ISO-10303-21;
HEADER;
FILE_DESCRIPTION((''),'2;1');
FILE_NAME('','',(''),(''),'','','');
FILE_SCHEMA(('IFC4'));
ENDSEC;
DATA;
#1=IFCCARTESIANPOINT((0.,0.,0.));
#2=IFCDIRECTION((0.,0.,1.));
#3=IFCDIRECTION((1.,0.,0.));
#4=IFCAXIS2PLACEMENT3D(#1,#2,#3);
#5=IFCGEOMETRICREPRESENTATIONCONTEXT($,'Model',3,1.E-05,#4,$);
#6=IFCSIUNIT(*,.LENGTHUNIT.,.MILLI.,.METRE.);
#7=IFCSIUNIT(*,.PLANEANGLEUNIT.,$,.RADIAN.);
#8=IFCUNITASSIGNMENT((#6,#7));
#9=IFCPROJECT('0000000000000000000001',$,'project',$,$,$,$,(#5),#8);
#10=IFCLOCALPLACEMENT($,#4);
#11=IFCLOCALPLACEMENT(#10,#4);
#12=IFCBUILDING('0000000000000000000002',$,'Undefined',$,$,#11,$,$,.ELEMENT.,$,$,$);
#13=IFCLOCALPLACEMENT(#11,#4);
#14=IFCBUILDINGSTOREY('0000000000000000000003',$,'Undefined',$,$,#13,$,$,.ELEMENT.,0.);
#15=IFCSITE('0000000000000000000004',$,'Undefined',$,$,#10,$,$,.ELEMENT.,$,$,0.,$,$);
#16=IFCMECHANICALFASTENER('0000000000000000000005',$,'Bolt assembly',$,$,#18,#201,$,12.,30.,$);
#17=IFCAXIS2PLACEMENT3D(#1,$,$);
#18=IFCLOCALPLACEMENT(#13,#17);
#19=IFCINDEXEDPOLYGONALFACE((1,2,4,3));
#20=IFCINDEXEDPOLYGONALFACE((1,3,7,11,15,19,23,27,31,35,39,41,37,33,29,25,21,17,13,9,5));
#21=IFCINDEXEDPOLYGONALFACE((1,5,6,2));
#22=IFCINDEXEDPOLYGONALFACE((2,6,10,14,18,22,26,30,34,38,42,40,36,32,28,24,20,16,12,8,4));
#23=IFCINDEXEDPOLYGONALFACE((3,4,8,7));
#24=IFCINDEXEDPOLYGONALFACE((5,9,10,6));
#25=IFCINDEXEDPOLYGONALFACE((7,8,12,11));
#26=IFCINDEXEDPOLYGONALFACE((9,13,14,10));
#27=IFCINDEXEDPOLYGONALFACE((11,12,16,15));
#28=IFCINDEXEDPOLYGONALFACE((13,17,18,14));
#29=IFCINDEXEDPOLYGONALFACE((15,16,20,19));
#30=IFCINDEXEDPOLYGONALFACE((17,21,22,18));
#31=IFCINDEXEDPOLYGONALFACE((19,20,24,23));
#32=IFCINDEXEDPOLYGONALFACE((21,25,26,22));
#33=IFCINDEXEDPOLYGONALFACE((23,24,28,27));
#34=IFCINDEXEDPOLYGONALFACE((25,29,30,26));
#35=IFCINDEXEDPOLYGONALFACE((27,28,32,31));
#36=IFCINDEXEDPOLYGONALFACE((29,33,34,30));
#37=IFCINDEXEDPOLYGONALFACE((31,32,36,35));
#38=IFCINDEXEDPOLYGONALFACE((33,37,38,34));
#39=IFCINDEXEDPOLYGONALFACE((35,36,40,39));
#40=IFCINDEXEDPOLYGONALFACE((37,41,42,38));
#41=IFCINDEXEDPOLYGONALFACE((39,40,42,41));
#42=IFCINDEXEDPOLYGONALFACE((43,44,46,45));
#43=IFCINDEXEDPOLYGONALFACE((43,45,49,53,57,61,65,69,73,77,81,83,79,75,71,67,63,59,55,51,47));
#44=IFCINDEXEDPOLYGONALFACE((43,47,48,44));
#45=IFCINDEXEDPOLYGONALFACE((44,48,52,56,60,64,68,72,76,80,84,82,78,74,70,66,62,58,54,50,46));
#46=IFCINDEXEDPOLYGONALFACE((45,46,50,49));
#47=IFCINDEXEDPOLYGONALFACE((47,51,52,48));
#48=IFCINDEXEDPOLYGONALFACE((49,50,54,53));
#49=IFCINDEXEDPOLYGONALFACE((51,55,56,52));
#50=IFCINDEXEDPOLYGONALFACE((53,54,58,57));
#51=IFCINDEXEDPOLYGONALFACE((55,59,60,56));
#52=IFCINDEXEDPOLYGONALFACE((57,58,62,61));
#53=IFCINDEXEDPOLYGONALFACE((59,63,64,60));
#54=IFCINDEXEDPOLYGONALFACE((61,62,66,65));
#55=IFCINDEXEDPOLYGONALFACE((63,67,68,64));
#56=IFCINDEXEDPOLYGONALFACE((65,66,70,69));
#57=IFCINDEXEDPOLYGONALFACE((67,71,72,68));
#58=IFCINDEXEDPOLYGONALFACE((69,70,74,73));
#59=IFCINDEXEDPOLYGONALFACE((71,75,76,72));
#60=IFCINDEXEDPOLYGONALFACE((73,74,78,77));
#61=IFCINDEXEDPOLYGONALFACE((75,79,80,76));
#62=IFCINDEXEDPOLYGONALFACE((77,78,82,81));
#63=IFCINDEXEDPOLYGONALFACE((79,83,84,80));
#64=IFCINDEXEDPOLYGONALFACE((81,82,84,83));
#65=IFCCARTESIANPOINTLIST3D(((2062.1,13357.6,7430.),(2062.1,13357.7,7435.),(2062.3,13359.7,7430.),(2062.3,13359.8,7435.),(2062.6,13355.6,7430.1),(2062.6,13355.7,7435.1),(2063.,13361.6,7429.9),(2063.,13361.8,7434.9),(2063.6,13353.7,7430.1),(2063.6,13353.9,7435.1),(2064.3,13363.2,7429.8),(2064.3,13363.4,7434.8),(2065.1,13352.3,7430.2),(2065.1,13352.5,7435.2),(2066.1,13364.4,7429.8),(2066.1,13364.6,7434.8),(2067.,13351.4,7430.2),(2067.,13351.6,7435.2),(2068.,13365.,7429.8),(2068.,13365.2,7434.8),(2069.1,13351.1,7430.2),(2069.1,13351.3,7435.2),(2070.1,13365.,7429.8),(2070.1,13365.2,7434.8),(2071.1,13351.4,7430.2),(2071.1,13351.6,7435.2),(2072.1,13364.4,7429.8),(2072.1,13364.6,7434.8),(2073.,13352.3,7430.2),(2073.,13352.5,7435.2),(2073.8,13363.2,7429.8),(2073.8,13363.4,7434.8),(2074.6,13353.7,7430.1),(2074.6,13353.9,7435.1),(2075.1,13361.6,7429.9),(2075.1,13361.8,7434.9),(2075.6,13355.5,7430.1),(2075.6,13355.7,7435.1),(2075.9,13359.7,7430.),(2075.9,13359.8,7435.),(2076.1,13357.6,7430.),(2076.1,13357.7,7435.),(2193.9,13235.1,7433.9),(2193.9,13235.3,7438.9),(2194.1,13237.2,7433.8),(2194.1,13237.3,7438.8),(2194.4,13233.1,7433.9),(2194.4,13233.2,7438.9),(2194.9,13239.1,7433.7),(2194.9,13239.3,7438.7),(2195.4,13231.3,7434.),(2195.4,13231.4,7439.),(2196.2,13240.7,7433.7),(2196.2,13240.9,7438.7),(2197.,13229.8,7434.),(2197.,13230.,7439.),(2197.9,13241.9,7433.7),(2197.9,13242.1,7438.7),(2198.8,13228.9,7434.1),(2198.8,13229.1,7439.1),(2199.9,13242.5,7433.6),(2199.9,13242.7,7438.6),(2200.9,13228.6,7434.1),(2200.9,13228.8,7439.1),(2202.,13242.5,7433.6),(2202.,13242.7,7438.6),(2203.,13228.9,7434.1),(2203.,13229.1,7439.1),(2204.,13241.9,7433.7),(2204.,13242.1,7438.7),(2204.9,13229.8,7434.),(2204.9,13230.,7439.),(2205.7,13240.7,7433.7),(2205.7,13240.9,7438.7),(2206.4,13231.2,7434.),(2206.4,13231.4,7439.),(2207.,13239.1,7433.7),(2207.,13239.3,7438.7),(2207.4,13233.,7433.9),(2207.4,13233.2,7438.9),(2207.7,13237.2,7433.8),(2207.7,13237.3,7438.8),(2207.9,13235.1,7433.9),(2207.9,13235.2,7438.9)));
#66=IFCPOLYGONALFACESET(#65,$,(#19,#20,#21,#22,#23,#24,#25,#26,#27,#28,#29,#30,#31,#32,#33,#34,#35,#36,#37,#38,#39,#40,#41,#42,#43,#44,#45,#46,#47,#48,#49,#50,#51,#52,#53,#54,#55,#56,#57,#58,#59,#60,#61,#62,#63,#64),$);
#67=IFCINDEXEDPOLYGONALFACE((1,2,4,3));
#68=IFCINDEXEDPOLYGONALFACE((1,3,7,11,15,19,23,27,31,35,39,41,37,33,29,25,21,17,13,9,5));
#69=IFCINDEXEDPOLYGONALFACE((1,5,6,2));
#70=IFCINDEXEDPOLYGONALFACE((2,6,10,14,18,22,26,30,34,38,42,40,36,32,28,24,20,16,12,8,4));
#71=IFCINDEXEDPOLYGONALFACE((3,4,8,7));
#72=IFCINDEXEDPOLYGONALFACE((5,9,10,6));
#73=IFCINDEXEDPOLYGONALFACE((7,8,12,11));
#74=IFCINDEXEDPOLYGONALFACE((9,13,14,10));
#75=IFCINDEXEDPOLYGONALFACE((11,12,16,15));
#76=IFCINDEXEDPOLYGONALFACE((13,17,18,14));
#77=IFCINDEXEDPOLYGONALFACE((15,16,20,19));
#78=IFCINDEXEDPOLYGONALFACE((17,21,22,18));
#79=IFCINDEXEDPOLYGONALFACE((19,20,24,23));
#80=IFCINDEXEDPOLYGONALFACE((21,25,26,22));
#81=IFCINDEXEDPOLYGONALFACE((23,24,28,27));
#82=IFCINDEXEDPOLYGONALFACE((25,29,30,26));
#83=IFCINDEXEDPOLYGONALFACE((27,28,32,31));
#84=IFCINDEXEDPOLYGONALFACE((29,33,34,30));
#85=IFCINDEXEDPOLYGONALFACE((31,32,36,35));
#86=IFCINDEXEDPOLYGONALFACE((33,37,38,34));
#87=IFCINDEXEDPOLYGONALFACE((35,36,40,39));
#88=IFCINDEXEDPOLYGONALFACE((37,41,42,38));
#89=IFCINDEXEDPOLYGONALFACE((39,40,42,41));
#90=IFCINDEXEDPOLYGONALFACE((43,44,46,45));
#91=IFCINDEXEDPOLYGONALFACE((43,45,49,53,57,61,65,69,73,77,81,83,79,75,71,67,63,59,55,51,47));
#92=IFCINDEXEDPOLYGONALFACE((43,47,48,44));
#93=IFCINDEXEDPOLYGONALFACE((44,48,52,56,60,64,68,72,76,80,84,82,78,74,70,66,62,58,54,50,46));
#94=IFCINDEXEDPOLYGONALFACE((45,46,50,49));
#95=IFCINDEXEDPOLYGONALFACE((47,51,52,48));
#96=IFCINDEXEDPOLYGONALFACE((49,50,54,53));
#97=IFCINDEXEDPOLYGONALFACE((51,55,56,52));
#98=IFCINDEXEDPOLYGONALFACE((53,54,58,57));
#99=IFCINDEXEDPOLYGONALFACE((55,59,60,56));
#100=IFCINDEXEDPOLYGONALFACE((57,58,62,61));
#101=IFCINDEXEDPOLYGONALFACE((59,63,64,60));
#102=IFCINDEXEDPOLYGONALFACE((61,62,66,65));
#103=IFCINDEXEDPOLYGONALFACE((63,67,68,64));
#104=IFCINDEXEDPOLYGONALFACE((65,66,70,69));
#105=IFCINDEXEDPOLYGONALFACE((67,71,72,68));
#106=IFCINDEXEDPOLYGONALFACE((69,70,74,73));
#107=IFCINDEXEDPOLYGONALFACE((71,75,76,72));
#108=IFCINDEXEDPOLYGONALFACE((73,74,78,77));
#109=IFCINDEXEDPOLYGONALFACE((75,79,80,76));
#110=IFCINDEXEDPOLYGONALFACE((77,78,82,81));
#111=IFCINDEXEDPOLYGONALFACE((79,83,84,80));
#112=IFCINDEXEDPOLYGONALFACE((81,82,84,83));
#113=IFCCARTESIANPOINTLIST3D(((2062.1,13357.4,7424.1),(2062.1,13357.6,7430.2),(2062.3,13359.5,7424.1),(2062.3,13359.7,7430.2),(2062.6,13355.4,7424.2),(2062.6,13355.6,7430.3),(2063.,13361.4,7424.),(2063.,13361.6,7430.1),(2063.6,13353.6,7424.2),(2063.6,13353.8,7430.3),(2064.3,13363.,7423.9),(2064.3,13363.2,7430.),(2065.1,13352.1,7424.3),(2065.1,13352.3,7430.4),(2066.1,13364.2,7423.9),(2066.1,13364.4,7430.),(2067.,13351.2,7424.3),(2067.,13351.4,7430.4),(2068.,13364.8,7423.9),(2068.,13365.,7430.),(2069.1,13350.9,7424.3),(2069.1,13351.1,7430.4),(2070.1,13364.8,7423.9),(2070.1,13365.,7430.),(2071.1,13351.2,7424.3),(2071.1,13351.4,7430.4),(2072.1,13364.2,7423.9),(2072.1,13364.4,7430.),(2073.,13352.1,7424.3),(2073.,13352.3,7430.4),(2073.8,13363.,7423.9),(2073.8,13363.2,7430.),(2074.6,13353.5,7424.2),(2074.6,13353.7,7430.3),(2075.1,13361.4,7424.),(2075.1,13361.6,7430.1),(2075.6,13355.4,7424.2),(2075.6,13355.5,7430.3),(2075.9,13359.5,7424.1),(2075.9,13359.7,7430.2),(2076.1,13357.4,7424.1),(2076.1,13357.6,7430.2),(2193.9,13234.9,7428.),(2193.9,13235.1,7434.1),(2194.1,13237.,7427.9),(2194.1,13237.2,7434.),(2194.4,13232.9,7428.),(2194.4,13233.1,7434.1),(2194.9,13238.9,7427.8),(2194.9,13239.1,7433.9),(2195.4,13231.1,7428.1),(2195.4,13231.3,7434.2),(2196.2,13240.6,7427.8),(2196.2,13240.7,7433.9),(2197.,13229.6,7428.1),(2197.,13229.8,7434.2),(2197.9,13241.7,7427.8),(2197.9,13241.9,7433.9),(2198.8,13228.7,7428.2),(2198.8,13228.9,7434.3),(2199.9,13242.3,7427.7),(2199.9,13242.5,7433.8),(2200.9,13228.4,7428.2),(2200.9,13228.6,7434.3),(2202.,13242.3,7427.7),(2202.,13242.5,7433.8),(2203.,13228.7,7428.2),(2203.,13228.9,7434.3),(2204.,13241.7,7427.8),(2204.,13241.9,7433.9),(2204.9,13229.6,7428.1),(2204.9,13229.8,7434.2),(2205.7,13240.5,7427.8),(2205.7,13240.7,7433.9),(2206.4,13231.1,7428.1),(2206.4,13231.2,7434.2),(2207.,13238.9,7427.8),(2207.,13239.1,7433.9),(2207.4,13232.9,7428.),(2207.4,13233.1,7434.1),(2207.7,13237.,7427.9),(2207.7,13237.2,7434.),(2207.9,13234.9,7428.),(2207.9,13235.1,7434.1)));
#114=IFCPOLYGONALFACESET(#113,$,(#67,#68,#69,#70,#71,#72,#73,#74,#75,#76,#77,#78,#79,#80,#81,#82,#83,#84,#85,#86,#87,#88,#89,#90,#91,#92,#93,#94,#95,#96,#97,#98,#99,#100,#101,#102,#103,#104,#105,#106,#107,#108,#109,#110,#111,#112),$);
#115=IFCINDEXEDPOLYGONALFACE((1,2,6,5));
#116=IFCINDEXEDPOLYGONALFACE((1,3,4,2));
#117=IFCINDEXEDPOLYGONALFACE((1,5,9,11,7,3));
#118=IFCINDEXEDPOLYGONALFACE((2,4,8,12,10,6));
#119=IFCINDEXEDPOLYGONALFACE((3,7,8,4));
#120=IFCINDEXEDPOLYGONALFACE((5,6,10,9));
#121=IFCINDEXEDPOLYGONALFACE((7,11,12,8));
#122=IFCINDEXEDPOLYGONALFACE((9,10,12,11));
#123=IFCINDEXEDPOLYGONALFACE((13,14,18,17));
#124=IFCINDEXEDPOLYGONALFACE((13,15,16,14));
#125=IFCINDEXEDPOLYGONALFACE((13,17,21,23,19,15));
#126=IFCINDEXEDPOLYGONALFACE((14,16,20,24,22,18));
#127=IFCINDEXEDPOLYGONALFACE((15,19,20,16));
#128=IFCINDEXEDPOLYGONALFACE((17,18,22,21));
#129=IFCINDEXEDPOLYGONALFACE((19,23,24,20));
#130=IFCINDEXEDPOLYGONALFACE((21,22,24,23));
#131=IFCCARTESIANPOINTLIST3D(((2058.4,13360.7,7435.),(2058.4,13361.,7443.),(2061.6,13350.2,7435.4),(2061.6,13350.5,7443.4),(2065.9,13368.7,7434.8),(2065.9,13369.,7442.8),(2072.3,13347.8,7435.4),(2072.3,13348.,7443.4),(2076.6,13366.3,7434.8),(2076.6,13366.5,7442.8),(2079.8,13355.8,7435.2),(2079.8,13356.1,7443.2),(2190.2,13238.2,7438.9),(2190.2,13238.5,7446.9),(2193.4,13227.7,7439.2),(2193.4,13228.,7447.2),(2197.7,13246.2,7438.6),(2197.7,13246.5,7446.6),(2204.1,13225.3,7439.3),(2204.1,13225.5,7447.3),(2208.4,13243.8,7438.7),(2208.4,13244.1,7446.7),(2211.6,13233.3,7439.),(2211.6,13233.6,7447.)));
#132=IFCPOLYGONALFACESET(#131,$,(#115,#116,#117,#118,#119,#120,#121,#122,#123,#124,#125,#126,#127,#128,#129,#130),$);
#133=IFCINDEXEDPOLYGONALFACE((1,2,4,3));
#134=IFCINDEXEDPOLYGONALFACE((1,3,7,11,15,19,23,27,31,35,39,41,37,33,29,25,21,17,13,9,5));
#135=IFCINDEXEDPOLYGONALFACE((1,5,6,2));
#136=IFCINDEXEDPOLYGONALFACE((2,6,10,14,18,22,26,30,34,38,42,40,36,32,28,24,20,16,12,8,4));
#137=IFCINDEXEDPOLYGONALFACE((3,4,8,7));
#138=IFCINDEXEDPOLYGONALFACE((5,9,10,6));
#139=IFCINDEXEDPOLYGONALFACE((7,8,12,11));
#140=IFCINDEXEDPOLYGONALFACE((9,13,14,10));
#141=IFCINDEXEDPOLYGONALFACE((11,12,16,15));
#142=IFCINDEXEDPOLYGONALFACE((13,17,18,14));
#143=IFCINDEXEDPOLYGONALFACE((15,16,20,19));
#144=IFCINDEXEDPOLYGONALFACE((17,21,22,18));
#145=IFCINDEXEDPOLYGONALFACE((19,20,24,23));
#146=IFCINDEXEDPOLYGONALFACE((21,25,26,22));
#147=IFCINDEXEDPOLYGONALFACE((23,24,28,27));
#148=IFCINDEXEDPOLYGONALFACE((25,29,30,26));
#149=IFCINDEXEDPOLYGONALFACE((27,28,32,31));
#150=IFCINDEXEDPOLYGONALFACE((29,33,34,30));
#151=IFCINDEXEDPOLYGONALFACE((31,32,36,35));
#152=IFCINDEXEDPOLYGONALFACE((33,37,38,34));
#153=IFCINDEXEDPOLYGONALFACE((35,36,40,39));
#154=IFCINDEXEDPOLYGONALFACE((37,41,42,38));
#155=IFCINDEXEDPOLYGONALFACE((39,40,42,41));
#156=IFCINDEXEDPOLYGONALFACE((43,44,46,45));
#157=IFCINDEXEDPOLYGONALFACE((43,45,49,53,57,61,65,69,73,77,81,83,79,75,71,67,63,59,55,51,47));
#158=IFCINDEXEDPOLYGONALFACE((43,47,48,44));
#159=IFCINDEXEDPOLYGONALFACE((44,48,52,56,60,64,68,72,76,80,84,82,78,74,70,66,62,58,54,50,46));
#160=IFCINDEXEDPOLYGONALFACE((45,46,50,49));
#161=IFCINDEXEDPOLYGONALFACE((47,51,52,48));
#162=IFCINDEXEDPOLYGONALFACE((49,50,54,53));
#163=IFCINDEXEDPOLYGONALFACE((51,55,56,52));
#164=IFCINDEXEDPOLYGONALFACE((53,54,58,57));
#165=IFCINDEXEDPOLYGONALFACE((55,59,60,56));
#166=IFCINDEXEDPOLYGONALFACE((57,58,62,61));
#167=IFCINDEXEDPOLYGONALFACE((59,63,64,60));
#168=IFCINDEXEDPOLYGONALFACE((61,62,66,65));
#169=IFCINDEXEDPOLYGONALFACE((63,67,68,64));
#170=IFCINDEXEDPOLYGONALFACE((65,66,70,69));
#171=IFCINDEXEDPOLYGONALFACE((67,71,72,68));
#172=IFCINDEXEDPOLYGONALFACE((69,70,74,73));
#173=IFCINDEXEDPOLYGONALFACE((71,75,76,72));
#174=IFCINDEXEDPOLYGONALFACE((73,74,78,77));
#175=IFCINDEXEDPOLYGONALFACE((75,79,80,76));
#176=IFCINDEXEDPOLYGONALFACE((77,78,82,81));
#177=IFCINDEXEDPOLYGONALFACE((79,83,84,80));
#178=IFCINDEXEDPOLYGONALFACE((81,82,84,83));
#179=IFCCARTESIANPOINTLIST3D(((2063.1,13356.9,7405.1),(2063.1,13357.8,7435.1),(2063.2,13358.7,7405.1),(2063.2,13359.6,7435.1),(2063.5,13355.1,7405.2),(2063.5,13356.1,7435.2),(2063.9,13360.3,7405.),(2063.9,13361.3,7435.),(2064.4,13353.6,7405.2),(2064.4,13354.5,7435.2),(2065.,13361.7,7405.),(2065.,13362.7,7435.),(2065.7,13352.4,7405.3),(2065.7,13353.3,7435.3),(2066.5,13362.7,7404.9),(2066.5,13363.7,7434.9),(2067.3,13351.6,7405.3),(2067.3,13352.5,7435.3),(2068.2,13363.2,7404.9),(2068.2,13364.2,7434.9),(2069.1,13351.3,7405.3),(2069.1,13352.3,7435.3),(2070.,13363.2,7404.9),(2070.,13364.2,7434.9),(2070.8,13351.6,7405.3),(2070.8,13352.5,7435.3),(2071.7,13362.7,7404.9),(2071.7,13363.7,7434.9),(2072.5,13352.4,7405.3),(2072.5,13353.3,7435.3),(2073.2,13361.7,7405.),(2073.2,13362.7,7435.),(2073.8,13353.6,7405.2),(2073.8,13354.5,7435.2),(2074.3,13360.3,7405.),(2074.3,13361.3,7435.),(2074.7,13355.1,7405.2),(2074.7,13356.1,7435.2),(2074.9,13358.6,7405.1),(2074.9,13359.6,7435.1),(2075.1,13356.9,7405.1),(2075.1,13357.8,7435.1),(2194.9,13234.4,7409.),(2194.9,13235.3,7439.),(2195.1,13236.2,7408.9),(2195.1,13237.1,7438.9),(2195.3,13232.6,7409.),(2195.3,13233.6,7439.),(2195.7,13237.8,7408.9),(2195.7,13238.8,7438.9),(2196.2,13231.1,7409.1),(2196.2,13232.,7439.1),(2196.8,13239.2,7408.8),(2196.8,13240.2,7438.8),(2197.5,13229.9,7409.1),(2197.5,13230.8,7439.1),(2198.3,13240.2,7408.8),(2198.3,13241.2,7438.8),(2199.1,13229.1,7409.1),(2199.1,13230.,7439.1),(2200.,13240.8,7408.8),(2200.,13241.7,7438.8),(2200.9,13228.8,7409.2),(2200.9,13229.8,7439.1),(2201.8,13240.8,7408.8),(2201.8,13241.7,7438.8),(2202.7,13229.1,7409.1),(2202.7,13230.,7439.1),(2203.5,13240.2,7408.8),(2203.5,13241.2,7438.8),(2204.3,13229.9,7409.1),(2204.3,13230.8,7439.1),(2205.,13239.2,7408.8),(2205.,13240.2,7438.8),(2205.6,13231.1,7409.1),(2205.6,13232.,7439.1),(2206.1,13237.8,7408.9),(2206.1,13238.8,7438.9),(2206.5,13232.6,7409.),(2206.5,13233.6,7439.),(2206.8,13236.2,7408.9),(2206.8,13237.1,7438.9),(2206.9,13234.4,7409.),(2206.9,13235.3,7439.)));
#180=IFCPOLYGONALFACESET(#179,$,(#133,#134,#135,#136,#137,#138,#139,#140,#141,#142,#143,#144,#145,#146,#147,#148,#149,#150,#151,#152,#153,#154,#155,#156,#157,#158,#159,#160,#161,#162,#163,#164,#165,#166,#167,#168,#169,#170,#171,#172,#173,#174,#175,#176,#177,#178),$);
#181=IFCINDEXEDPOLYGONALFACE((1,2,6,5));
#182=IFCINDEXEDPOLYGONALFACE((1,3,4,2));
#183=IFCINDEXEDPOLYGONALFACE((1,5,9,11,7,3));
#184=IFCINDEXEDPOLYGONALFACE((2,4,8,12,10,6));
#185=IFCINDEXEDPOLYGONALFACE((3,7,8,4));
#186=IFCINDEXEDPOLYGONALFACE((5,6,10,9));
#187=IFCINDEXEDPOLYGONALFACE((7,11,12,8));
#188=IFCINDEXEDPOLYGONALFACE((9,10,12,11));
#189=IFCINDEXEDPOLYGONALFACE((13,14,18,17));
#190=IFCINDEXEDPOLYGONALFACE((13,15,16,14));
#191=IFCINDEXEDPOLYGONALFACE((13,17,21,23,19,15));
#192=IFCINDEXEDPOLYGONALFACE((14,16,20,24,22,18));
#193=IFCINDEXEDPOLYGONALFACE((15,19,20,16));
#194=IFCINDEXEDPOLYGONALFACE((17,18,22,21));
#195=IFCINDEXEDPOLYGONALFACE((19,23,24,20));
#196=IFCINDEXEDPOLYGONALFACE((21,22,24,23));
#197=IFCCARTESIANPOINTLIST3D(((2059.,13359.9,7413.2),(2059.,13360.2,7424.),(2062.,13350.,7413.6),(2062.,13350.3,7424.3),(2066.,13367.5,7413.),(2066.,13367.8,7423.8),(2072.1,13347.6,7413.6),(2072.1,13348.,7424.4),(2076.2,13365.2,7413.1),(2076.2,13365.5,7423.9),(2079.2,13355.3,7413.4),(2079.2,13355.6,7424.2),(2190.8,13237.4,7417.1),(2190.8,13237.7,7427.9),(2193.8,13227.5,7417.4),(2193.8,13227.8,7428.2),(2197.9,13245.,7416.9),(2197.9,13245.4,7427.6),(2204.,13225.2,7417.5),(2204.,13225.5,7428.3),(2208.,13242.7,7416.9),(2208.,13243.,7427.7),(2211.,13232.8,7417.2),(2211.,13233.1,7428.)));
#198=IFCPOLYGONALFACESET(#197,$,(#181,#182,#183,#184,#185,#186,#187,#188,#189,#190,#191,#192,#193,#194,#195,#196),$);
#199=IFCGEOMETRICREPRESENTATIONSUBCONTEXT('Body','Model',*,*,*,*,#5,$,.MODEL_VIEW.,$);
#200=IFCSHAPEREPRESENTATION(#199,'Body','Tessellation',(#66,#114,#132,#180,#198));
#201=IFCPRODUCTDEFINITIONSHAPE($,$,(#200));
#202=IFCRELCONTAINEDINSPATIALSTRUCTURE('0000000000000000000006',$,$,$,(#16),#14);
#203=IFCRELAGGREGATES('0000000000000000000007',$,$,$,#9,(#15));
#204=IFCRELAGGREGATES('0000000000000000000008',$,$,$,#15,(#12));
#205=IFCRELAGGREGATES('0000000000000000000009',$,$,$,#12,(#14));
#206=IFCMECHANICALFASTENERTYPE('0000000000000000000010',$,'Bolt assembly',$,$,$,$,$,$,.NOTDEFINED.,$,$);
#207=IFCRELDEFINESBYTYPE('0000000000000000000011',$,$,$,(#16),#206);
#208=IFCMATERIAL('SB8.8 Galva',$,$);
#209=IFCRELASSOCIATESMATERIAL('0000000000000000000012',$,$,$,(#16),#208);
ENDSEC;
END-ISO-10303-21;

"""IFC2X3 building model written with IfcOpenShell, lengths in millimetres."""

from ifc_helpers import new_model, si_unit, frame, origin_with_axes, origin_2d_with_axis, place, context, subcontext, project, spatial, polyline, circle, outline, extrude, source, transform, mapped, material, type_object, element, save


model = new_model("IFC2X3")

# Units and contexts
model_context = context("Model", 3, precision=1e-05, world=origin_with_axes())
body_context = subcontext(model_context, "Body", "Model", "MODEL_VIEW")
ifc_project = project(units=[si_unit("LENGTHUNIT", "METRE", prefix="MILLI"), si_unit("PLANEANGLEUNIT", "RADIAN")], contexts=[model_context])

# Site, building, storey
site_placement = place(None, origin_with_axes())
site = spatial("IfcSite", under=ifc_project, at=site_placement, Name="Undefined", CompositionType="ELEMENT", RefElevation=0.0)
building_placement = place(site_placement, origin_with_axes())
building = spatial("IfcBuilding", under=site, at=building_placement, Name="Undefined", CompositionType="ELEMENT")
storey_placement = place(building_placement, origin_with_axes())
storey = spatial("IfcBuildingStorey", under=building, at=storey_placement, Name="Undefined", CompositionType="ELEMENT", Elevation=0.0)

# Mechanical fastener
mechanical_fastener_type = type_object("IfcMechanicalFastenerType", Name="Bolt assembly")
ifc_material_1 = material(Name="SB8.8 Galva")
shared_shape_1 = source(origin_with_axes(), body_context, "Body", "SweptSolid", [
    extrude(circle(Radius=7.0, at=origin_2d_with_axis()), frame((0.0, -4.9, 0.0), z_axis=(0.0, 1.0, 0.0), x_axis=(1.0, 0.0, 0.0)), (0.0, 0.0, 1.0), 5.0),
    extrude(circle(Radius=7.0, at=origin_2d_with_axis()), frame((0.0, -0.1, 0.0), z_axis=(0.0, 1.0, 0.0), x_axis=(1.0, 0.0, 0.0)), (0.0, 0.0, 1.0), 6.1),
    extrude(outline(polyline([(11.0, 0.0), (5.5, 9.5), (-5.5, 9.5), (-11.0, 0.0), (-5.5, -9.5), (5.5, -9.5), (11.0, 0.0)])), frame((0.0, -13.0, 0.0), z_axis=(0.0, 1.0, 0.0), x_axis=(1.0, 0.0, 0.0)), (0.0, 0.0, 1.0), 8.0),
    extrude(circle(Radius=6.0, at=origin_2d_with_axis()), frame((0.0, -5.0, 0.0), z_axis=(0.0, 1.0, 0.0), x_axis=(1.0, 0.0, 0.0)), (0.0, 0.0, 1.0), 30.0),
    extrude(outline(polyline([(10.4, 0.0), (5.2, 9.0), (-5.2, 9.0), (-10.4, 0.0), (-5.2, -9.0), (5.2, -9.0), (10.4, 0.0)])), frame((0.0, 6.0, 0.0), z_axis=(0.0, 1.0, 0.0), x_axis=(1.0, 0.0, 0.0)), (0.0, 0.0, 1.0), 10.8),
])
mechanical_fastener_1_placement = place(storey_placement, frame((2135.0, 13296.9, 7432.0), z_axis=(-0.732427, 0.680509, -0.021386), x_axis=(0.680845, 0.732066, -0.023006)))
element("IfcMechanicalFastener", 1, at=mechanical_fastener_1_placement, inside=storey, type_object=mechanical_fastener_type, material=ifc_material_1, Name="Bolt assembly", NominalDiameter=12.0, NominalLength=30.0, context=body_context, shape_type="MappedRepresentation", body=[
    mapped(shared_shape_1, transform((0.0, 0.0, -90.0))),
    mapped(shared_shape_1, transform((0.0, 0.0, 90.0))),
])

save(model, "model.ifc")
